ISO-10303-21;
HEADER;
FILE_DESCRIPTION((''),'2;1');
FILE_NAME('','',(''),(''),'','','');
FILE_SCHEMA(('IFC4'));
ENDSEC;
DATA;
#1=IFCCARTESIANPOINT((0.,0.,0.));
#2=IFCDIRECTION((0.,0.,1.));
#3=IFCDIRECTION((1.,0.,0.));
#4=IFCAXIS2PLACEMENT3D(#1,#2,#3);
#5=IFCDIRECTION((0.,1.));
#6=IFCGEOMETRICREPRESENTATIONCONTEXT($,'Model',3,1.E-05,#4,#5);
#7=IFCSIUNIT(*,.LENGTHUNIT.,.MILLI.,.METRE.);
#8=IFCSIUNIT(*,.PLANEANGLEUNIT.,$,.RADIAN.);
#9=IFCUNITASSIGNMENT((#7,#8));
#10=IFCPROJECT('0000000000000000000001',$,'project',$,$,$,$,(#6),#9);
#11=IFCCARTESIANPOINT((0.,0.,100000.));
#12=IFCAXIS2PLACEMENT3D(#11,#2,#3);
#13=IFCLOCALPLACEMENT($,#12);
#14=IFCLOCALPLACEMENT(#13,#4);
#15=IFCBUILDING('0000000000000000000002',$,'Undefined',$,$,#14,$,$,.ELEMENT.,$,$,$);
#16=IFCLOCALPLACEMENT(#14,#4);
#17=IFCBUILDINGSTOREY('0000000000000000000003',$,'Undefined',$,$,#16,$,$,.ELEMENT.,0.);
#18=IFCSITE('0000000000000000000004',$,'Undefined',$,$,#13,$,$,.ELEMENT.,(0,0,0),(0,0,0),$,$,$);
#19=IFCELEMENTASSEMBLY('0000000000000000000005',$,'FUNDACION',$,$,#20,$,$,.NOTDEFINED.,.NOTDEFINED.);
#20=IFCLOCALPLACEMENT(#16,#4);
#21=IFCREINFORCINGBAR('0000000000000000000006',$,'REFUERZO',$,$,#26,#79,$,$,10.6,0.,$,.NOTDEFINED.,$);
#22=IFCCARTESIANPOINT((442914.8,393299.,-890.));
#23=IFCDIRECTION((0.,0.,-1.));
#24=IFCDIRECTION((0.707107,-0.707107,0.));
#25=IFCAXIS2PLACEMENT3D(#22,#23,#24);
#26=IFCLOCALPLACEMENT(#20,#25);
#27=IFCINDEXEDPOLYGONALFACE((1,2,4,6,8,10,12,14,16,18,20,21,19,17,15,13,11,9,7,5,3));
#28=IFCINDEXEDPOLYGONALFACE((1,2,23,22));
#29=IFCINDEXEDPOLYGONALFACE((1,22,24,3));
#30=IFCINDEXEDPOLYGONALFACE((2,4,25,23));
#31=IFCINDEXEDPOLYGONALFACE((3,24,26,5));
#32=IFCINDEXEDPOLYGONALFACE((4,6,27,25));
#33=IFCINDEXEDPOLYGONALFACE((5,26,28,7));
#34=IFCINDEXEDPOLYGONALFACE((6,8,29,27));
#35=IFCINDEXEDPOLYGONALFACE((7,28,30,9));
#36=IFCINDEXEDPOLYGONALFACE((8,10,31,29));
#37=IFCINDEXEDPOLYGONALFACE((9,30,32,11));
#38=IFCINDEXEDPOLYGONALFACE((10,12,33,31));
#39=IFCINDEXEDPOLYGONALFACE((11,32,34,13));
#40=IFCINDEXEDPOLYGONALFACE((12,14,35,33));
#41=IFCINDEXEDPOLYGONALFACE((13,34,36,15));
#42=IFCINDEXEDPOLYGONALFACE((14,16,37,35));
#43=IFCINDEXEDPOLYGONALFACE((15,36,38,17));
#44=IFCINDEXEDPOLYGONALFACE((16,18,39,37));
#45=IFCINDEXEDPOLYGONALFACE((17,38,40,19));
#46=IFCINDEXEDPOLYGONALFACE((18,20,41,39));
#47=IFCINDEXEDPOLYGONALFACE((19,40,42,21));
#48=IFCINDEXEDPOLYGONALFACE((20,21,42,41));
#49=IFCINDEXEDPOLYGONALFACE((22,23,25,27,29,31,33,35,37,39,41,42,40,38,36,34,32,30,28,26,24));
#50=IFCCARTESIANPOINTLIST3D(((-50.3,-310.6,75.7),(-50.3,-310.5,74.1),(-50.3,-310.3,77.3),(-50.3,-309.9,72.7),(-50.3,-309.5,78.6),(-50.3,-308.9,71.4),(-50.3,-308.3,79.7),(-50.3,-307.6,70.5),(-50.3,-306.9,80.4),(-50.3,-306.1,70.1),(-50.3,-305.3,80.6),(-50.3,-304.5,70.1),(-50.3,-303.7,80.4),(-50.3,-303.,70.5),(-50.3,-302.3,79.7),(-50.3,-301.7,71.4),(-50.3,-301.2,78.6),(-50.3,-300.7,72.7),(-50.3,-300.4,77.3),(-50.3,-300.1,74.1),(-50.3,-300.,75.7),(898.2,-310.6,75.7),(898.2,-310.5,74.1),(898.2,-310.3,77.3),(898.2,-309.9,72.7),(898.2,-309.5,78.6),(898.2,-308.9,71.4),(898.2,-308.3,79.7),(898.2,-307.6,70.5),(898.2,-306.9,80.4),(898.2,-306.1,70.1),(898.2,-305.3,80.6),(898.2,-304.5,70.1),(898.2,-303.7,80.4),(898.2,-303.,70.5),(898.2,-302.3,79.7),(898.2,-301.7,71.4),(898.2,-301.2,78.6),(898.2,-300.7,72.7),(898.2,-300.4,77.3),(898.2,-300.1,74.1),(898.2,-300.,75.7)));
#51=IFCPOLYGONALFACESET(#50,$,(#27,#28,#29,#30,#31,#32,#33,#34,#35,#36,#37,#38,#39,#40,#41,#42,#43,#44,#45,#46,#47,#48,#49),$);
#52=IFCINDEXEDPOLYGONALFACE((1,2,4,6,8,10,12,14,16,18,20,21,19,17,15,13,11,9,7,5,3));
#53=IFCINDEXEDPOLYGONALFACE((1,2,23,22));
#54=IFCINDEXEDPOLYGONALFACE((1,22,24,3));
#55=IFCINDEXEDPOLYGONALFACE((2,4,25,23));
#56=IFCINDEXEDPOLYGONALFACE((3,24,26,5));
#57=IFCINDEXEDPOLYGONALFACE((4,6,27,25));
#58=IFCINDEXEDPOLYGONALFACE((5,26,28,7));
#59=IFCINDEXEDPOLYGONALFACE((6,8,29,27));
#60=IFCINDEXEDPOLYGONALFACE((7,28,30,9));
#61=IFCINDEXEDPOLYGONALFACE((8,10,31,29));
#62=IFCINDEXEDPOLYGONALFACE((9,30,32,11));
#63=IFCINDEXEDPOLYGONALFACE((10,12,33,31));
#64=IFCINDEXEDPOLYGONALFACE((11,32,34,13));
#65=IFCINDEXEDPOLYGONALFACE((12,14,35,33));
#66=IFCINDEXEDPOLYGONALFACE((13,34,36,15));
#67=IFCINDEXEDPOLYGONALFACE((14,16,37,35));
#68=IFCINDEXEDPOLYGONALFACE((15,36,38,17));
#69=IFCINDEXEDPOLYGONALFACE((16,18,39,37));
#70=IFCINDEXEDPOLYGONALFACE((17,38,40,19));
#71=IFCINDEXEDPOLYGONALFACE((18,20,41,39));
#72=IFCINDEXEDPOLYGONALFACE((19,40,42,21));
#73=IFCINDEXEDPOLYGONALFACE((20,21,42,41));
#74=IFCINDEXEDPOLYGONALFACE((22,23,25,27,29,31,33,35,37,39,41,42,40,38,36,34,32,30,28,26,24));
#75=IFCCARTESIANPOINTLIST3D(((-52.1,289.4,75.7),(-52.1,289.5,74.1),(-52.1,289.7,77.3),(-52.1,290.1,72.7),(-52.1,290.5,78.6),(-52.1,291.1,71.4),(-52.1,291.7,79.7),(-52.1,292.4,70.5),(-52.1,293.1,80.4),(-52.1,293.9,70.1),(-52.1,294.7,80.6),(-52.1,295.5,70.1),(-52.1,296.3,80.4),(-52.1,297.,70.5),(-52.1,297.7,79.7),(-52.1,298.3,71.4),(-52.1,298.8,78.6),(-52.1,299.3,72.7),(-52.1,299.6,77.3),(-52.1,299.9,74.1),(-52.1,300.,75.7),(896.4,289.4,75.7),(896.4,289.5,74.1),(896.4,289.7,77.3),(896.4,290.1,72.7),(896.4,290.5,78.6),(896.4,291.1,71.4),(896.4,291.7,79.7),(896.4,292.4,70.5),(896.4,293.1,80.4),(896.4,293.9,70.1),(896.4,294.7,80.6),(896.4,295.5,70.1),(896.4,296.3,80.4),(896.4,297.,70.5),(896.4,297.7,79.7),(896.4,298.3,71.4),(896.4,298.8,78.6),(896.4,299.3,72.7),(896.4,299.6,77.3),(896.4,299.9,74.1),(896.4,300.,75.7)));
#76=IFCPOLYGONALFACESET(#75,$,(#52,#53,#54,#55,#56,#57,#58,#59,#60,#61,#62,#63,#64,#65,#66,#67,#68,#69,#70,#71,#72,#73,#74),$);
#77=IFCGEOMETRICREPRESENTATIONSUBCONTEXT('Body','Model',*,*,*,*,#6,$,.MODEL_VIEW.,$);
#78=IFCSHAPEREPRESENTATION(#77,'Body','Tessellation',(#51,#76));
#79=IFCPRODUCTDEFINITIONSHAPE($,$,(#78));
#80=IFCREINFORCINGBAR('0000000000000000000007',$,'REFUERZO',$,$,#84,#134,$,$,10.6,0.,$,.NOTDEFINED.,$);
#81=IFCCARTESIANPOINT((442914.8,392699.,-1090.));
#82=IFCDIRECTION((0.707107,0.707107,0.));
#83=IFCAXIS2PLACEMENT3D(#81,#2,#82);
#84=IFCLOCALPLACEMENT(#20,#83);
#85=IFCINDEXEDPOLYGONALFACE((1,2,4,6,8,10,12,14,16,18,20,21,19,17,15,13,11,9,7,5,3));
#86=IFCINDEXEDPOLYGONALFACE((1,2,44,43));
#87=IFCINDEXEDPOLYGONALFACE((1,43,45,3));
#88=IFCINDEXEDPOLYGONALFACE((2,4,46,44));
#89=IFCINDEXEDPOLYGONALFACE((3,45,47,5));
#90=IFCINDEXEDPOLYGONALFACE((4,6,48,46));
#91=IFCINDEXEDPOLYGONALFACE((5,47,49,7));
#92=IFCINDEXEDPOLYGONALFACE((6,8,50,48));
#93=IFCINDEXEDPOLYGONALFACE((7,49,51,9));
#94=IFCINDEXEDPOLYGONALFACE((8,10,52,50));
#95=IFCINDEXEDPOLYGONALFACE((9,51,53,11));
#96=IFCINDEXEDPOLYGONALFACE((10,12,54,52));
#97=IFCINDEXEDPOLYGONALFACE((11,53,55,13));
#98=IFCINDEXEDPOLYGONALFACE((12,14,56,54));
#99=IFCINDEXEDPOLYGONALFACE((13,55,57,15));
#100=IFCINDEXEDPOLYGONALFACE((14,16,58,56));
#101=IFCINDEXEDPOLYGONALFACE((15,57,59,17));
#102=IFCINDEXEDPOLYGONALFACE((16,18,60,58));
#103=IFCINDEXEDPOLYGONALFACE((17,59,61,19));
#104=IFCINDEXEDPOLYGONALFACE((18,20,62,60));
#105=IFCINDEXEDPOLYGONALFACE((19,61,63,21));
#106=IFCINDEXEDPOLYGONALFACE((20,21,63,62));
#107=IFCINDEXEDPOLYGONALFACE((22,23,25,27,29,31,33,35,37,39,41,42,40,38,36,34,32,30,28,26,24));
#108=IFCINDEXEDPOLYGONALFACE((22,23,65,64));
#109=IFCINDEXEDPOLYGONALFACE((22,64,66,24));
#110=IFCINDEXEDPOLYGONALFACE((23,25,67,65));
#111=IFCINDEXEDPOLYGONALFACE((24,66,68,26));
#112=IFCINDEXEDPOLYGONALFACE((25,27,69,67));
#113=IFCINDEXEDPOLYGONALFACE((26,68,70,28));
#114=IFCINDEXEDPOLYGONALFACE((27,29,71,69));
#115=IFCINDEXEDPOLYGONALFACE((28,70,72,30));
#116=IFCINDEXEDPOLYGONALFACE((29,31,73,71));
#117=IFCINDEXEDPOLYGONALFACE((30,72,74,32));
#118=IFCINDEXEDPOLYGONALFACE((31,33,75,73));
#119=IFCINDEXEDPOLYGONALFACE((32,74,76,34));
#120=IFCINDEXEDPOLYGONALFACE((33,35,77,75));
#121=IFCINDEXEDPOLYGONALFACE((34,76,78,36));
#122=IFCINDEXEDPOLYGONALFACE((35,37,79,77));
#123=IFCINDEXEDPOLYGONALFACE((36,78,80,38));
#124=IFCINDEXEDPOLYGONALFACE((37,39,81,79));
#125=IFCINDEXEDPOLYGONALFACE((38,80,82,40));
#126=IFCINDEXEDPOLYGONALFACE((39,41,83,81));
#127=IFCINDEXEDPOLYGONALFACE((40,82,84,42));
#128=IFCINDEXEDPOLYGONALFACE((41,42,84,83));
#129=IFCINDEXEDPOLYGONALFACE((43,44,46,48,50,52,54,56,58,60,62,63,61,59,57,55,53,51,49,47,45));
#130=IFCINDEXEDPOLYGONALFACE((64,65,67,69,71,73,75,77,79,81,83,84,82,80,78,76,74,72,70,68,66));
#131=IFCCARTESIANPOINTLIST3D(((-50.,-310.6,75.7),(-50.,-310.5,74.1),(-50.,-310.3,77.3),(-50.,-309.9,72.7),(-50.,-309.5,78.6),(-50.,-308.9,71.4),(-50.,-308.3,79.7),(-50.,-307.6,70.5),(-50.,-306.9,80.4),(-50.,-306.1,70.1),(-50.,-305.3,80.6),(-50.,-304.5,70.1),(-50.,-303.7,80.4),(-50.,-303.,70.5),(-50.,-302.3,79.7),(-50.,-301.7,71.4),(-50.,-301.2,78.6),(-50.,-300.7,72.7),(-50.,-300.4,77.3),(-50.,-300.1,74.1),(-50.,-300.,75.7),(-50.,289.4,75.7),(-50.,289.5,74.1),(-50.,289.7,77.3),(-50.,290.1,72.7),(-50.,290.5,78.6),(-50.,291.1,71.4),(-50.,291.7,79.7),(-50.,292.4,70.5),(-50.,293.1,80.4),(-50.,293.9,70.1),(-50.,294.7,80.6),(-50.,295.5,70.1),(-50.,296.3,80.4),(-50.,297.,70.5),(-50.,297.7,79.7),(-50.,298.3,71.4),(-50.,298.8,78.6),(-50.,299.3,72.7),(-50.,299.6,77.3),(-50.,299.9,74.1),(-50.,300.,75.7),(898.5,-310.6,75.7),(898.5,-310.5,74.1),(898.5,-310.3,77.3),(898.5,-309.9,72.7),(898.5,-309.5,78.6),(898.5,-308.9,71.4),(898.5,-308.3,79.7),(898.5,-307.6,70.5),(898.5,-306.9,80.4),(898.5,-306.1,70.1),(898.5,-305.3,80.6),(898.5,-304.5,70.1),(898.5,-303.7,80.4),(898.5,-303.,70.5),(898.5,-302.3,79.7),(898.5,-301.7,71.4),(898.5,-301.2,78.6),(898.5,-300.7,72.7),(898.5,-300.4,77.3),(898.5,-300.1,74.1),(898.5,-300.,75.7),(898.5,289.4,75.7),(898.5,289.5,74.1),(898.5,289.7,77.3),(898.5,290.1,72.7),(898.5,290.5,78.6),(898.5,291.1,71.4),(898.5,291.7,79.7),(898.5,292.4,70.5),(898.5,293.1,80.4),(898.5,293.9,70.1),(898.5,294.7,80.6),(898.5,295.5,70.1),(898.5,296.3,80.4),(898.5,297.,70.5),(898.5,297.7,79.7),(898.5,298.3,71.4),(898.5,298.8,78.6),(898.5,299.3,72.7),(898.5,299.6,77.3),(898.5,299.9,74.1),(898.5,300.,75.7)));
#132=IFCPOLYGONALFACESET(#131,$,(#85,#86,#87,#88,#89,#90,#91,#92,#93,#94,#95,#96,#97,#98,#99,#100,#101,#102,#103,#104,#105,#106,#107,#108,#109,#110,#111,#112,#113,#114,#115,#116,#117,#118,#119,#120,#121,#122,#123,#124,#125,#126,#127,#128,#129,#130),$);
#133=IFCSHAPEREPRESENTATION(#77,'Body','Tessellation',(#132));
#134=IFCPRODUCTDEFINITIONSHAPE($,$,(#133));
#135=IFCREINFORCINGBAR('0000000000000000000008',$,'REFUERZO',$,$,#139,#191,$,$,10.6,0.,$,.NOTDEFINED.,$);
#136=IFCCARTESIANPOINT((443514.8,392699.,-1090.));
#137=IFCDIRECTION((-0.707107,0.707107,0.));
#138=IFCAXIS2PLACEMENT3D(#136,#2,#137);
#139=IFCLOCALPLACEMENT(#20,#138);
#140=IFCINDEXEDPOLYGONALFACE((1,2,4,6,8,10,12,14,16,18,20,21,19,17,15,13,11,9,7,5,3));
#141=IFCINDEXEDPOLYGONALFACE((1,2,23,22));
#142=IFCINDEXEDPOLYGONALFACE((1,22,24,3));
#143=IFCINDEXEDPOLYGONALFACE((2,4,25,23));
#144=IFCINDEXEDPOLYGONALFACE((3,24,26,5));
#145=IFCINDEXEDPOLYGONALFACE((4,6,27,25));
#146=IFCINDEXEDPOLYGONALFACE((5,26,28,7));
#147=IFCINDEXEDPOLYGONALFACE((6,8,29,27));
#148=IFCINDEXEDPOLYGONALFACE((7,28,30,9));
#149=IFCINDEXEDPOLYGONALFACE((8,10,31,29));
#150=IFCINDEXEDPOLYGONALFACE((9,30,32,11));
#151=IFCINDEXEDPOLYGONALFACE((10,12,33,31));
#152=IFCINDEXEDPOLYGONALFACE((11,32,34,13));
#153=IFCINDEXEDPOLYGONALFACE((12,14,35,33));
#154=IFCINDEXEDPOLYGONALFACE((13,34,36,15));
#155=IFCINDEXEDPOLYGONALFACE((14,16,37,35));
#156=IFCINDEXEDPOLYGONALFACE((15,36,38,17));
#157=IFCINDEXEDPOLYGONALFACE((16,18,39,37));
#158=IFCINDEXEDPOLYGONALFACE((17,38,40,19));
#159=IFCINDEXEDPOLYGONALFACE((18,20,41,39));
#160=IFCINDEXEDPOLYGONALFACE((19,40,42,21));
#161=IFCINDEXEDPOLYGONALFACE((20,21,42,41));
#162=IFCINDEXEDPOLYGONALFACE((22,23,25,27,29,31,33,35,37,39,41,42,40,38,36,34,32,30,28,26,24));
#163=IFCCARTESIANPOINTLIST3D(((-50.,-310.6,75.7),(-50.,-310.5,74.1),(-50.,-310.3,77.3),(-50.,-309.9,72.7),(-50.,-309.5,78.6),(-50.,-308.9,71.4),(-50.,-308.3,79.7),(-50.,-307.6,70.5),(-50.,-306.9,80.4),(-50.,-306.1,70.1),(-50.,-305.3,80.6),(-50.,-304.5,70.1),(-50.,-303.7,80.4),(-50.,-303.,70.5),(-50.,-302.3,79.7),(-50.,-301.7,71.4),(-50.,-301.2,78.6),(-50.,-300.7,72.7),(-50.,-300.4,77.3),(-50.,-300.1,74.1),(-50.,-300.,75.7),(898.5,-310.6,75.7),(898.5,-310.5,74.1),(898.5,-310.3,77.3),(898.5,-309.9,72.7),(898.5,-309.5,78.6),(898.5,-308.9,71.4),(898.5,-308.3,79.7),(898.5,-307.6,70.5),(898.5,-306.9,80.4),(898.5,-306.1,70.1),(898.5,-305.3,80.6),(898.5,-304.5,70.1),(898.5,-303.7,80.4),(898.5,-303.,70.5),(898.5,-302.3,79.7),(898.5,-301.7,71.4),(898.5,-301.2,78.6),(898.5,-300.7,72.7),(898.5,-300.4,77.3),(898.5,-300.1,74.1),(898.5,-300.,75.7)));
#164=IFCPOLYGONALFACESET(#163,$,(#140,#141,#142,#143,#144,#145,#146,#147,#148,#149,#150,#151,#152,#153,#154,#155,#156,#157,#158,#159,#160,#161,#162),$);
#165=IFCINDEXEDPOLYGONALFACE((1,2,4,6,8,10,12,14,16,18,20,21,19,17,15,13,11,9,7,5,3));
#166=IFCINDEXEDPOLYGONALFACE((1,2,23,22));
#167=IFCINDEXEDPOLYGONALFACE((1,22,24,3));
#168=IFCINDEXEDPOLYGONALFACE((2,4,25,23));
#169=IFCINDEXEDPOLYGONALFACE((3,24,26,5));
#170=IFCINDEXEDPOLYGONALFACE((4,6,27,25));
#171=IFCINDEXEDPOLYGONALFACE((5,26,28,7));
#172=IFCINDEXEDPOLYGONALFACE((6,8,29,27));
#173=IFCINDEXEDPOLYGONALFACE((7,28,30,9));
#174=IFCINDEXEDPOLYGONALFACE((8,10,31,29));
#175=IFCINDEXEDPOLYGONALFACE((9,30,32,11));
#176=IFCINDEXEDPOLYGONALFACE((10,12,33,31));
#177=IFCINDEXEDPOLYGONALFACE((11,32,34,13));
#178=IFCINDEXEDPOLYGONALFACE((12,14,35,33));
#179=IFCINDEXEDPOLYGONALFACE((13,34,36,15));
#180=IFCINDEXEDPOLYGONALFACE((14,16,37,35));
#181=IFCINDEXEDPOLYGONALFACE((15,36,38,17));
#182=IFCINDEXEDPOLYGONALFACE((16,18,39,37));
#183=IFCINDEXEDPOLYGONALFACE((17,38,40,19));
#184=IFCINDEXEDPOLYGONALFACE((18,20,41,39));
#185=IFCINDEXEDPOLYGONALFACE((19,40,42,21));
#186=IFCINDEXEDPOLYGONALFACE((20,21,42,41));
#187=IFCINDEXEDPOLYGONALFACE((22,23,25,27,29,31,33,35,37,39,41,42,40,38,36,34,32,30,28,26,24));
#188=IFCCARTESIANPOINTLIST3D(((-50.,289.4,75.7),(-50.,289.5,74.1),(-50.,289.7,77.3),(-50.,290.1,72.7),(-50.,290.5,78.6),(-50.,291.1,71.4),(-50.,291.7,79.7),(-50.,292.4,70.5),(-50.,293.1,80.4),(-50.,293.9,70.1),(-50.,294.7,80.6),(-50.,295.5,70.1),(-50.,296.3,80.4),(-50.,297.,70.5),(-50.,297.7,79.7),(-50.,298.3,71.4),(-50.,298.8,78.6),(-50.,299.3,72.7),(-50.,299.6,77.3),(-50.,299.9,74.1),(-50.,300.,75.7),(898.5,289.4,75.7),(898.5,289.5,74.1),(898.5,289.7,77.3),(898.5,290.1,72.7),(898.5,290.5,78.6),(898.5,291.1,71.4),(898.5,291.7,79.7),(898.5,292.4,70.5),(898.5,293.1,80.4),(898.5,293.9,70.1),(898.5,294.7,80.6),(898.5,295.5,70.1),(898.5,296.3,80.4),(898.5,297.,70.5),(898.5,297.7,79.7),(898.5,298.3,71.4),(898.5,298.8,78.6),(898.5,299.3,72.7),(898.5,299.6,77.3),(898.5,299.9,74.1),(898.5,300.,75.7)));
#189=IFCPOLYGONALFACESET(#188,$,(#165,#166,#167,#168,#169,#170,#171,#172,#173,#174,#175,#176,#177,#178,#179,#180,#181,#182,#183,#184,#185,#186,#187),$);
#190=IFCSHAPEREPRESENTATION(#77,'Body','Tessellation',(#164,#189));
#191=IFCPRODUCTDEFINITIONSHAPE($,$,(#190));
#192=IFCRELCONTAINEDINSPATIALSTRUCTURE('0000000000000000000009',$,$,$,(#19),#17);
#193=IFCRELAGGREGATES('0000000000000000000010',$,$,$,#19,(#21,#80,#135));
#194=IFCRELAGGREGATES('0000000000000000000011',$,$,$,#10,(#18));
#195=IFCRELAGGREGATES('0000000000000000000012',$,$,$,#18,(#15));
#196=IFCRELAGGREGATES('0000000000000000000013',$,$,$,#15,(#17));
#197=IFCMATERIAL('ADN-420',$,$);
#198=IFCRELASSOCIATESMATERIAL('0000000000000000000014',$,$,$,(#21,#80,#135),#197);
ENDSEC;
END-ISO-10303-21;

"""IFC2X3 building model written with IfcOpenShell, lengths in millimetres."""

from ifc_helpers import new_model, entity, si_unit, direction, frame, origin_with_axes, place, context, subcontext, project, spatial, source, transform, mapped, material, element, aggregate, save


model = new_model("IFC2X3")

# Units and contexts
model_context = context("Model", 3, precision=1e-05, world=origin_with_axes(), true_north=direction((0.0, 1.0)))
body_context = subcontext(model_context, "Body", "Model", "MODEL_VIEW")
ifc_project = project(units=[si_unit("LENGTHUNIT", "METRE", prefix="MILLI"), si_unit("PLANEANGLEUNIT", "RADIAN")], contexts=[model_context])

# Site, building, storey
site_placement = place(None, frame((0.0, 0.0, 100000.0), z_axis=(0.0, 0.0, 1.0), x_axis=(1.0, 0.0, 0.0)))
site = spatial("IfcSite", under=ifc_project, at=site_placement, Name="Undefined", CompositionType="ELEMENT", RefLatitude=(0, 0, 0), RefLongitude=(0, 0, 0))
building_placement = place(site_placement, origin_with_axes())
building = spatial("IfcBuilding", under=site, at=building_placement, Name="Undefined", CompositionType="ELEMENT")
storey_placement = place(building_placement, origin_with_axes())
storey = spatial("IfcBuildingStorey", under=building, at=storey_placement, Name="Undefined", CompositionType="ELEMENT", Elevation=0.0)

# Element assembly, reinforcing bars
assembly_1_placement = place(storey_placement, origin_with_axes())
assembly_1 = element("IfcElementAssembly", 1, at=assembly_1_placement, inside=storey, Name="FUNDACION", AssemblyPlace="NOTDEFINED", PredefinedType="NOTDEFINED")
ifc_material_1 = material(Name="ADN-420")
shared_shape_1 = source(origin_with_axes(), body_context, "Body", "AdvancedSweptSolid", [
    entity("IfcSweptDiskSolid", entity("IfcTrimmedCurve", entity("IfcLine", entity("IfcCartesianPoint", [0.0, 0.0, 0.0]), entity("IfcVector", entity("IfcDirection", [1.0, 0.0, 0.0]), 1.0)), [entity("IfcParameterValue", 0.0)], [entity("IfcParameterValue", 948.528137)], True, "PARAMETER"), 5.3, None, 0.0, 948.5),
])
shared_shape_2 = source(origin_with_axes(), body_context, "Body", "AdvancedSweptSolid", [
    entity("IfcSweptDiskSolid", entity("IfcTrimmedCurve", entity("IfcLine", entity("IfcCartesianPoint", [0.0, 0.0, 0.0]), entity("IfcVector", entity("IfcDirection", [1.0, 0.0, 0.0]), 1.0)), [entity("IfcParameterValue", 0.0)], [entity("IfcParameterValue", 948.528137)], True, "PARAMETER"), 5.3, None, 0.0, 948.5),
])
reinforcing_bar_1_placement = place(assembly_1_placement, frame((442914.8, 393299.0, -890.0), z_axis=(0.0, 0.0, -1.0), x_axis=(0.707107, -0.707107, 0.0)))
reinforcing_bar_1 = element("IfcReinforcingBar", 2, at=reinforcing_bar_1_placement, material=ifc_material_1, Name="REFUERZO", BarRole="NOTDEFINED", CrossSectionArea=0.0, NominalDiameter=10.6, context=body_context, shape_type="MappedRepresentation", body=[
    mapped(shared_shape_1, transform((-50.3, -305.3, 75.3))),
    mapped(shared_shape_2, transform((-52.1, 294.7, 75.3))),
])
shared_shape_3 = source(origin_with_axes(), body_context, "Body", "AdvancedSweptSolid", [
    entity("IfcSweptDiskSolid", entity("IfcTrimmedCurve", entity("IfcLine", entity("IfcCartesianPoint", [0.0, 0.0, 0.0]), entity("IfcVector", entity("IfcDirection", [1.0, 0.0, 0.0]), 1.0)), [entity("IfcParameterValue", 0.0)], [entity("IfcParameterValue", 948.528137)], True, "PARAMETER"), 5.3, None, 0.0, 948.5),
])
shared_shape_4 = source(origin_with_axes(), body_context, "Body", "AdvancedSweptSolid", [
    entity("IfcSweptDiskSolid", entity("IfcTrimmedCurve", entity("IfcLine", entity("IfcCartesianPoint", [0.0, 0.0, 0.0]), entity("IfcVector", entity("IfcDirection", [1.0, 0.0, 0.0]), 1.0)), [entity("IfcParameterValue", 0.0)], [entity("IfcParameterValue", 948.528137)], True, "PARAMETER"), 5.3, None, 0.0, 948.5),
])
reinforcing_bar_2_placement = place(assembly_1_placement, frame((442914.8, 392699.0, -1090.0), z_axis=(0.0, 0.0, 1.0), x_axis=(0.707107, 0.707107, 0.0)))
reinforcing_bar_2 = element("IfcReinforcingBar", 3, at=reinforcing_bar_2_placement, material=ifc_material_1, Name="REFUERZO", BarRole="NOTDEFINED", CrossSectionArea=0.0, NominalDiameter=10.6, context=body_context, shape_type="MappedRepresentation", body=[
    mapped(shared_shape_3, transform((-50.0, -305.3, 75.3))),
    mapped(shared_shape_4, transform((-50.0, 294.7, 75.3))),
])
shared_shape_5 = source(origin_with_axes(), body_context, "Body", "AdvancedSweptSolid", [
    entity("IfcSweptDiskSolid", entity("IfcTrimmedCurve", entity("IfcLine", entity("IfcCartesianPoint", [0.0, 0.0, 0.0]), entity("IfcVector", entity("IfcDirection", [1.0, 0.0, 0.0]), 1.0)), [entity("IfcParameterValue", 0.0)], [entity("IfcParameterValue", 948.528137)], True, "PARAMETER"), 5.3, None, 0.0, 948.5),
])
shared_shape_6 = source(origin_with_axes(), body_context, "Body", "AdvancedSweptSolid", [
    entity("IfcSweptDiskSolid", entity("IfcTrimmedCurve", entity("IfcLine", entity("IfcCartesianPoint", [0.0, 0.0, 0.0]), entity("IfcVector", entity("IfcDirection", [1.0, 0.0, 0.0]), 1.0)), [entity("IfcParameterValue", 0.0)], [entity("IfcParameterValue", 948.528137)], True, "PARAMETER"), 5.3, None, 0.0, 948.5),
])
reinforcing_bar_3_placement = place(assembly_1_placement, frame((443514.8, 392699.0, -1090.0), z_axis=(0.0, 0.0, 1.0), x_axis=(-0.707107, 0.707107, 0.0)))
reinforcing_bar_3 = element("IfcReinforcingBar", 4, at=reinforcing_bar_3_placement, material=ifc_material_1, Name="REFUERZO", BarRole="NOTDEFINED", CrossSectionArea=0.0, NominalDiameter=10.6, context=body_context, shape_type="MappedRepresentation", body=[
    mapped(shared_shape_5, transform((-50.0, -305.3, 75.3))),
    mapped(shared_shape_6, transform((-50.0, 294.7, 75.3))),
])
aggregate(assembly_1, [reinforcing_bar_1, reinforcing_bar_2, reinforcing_bar_3])

save(model, "model.ifc")
